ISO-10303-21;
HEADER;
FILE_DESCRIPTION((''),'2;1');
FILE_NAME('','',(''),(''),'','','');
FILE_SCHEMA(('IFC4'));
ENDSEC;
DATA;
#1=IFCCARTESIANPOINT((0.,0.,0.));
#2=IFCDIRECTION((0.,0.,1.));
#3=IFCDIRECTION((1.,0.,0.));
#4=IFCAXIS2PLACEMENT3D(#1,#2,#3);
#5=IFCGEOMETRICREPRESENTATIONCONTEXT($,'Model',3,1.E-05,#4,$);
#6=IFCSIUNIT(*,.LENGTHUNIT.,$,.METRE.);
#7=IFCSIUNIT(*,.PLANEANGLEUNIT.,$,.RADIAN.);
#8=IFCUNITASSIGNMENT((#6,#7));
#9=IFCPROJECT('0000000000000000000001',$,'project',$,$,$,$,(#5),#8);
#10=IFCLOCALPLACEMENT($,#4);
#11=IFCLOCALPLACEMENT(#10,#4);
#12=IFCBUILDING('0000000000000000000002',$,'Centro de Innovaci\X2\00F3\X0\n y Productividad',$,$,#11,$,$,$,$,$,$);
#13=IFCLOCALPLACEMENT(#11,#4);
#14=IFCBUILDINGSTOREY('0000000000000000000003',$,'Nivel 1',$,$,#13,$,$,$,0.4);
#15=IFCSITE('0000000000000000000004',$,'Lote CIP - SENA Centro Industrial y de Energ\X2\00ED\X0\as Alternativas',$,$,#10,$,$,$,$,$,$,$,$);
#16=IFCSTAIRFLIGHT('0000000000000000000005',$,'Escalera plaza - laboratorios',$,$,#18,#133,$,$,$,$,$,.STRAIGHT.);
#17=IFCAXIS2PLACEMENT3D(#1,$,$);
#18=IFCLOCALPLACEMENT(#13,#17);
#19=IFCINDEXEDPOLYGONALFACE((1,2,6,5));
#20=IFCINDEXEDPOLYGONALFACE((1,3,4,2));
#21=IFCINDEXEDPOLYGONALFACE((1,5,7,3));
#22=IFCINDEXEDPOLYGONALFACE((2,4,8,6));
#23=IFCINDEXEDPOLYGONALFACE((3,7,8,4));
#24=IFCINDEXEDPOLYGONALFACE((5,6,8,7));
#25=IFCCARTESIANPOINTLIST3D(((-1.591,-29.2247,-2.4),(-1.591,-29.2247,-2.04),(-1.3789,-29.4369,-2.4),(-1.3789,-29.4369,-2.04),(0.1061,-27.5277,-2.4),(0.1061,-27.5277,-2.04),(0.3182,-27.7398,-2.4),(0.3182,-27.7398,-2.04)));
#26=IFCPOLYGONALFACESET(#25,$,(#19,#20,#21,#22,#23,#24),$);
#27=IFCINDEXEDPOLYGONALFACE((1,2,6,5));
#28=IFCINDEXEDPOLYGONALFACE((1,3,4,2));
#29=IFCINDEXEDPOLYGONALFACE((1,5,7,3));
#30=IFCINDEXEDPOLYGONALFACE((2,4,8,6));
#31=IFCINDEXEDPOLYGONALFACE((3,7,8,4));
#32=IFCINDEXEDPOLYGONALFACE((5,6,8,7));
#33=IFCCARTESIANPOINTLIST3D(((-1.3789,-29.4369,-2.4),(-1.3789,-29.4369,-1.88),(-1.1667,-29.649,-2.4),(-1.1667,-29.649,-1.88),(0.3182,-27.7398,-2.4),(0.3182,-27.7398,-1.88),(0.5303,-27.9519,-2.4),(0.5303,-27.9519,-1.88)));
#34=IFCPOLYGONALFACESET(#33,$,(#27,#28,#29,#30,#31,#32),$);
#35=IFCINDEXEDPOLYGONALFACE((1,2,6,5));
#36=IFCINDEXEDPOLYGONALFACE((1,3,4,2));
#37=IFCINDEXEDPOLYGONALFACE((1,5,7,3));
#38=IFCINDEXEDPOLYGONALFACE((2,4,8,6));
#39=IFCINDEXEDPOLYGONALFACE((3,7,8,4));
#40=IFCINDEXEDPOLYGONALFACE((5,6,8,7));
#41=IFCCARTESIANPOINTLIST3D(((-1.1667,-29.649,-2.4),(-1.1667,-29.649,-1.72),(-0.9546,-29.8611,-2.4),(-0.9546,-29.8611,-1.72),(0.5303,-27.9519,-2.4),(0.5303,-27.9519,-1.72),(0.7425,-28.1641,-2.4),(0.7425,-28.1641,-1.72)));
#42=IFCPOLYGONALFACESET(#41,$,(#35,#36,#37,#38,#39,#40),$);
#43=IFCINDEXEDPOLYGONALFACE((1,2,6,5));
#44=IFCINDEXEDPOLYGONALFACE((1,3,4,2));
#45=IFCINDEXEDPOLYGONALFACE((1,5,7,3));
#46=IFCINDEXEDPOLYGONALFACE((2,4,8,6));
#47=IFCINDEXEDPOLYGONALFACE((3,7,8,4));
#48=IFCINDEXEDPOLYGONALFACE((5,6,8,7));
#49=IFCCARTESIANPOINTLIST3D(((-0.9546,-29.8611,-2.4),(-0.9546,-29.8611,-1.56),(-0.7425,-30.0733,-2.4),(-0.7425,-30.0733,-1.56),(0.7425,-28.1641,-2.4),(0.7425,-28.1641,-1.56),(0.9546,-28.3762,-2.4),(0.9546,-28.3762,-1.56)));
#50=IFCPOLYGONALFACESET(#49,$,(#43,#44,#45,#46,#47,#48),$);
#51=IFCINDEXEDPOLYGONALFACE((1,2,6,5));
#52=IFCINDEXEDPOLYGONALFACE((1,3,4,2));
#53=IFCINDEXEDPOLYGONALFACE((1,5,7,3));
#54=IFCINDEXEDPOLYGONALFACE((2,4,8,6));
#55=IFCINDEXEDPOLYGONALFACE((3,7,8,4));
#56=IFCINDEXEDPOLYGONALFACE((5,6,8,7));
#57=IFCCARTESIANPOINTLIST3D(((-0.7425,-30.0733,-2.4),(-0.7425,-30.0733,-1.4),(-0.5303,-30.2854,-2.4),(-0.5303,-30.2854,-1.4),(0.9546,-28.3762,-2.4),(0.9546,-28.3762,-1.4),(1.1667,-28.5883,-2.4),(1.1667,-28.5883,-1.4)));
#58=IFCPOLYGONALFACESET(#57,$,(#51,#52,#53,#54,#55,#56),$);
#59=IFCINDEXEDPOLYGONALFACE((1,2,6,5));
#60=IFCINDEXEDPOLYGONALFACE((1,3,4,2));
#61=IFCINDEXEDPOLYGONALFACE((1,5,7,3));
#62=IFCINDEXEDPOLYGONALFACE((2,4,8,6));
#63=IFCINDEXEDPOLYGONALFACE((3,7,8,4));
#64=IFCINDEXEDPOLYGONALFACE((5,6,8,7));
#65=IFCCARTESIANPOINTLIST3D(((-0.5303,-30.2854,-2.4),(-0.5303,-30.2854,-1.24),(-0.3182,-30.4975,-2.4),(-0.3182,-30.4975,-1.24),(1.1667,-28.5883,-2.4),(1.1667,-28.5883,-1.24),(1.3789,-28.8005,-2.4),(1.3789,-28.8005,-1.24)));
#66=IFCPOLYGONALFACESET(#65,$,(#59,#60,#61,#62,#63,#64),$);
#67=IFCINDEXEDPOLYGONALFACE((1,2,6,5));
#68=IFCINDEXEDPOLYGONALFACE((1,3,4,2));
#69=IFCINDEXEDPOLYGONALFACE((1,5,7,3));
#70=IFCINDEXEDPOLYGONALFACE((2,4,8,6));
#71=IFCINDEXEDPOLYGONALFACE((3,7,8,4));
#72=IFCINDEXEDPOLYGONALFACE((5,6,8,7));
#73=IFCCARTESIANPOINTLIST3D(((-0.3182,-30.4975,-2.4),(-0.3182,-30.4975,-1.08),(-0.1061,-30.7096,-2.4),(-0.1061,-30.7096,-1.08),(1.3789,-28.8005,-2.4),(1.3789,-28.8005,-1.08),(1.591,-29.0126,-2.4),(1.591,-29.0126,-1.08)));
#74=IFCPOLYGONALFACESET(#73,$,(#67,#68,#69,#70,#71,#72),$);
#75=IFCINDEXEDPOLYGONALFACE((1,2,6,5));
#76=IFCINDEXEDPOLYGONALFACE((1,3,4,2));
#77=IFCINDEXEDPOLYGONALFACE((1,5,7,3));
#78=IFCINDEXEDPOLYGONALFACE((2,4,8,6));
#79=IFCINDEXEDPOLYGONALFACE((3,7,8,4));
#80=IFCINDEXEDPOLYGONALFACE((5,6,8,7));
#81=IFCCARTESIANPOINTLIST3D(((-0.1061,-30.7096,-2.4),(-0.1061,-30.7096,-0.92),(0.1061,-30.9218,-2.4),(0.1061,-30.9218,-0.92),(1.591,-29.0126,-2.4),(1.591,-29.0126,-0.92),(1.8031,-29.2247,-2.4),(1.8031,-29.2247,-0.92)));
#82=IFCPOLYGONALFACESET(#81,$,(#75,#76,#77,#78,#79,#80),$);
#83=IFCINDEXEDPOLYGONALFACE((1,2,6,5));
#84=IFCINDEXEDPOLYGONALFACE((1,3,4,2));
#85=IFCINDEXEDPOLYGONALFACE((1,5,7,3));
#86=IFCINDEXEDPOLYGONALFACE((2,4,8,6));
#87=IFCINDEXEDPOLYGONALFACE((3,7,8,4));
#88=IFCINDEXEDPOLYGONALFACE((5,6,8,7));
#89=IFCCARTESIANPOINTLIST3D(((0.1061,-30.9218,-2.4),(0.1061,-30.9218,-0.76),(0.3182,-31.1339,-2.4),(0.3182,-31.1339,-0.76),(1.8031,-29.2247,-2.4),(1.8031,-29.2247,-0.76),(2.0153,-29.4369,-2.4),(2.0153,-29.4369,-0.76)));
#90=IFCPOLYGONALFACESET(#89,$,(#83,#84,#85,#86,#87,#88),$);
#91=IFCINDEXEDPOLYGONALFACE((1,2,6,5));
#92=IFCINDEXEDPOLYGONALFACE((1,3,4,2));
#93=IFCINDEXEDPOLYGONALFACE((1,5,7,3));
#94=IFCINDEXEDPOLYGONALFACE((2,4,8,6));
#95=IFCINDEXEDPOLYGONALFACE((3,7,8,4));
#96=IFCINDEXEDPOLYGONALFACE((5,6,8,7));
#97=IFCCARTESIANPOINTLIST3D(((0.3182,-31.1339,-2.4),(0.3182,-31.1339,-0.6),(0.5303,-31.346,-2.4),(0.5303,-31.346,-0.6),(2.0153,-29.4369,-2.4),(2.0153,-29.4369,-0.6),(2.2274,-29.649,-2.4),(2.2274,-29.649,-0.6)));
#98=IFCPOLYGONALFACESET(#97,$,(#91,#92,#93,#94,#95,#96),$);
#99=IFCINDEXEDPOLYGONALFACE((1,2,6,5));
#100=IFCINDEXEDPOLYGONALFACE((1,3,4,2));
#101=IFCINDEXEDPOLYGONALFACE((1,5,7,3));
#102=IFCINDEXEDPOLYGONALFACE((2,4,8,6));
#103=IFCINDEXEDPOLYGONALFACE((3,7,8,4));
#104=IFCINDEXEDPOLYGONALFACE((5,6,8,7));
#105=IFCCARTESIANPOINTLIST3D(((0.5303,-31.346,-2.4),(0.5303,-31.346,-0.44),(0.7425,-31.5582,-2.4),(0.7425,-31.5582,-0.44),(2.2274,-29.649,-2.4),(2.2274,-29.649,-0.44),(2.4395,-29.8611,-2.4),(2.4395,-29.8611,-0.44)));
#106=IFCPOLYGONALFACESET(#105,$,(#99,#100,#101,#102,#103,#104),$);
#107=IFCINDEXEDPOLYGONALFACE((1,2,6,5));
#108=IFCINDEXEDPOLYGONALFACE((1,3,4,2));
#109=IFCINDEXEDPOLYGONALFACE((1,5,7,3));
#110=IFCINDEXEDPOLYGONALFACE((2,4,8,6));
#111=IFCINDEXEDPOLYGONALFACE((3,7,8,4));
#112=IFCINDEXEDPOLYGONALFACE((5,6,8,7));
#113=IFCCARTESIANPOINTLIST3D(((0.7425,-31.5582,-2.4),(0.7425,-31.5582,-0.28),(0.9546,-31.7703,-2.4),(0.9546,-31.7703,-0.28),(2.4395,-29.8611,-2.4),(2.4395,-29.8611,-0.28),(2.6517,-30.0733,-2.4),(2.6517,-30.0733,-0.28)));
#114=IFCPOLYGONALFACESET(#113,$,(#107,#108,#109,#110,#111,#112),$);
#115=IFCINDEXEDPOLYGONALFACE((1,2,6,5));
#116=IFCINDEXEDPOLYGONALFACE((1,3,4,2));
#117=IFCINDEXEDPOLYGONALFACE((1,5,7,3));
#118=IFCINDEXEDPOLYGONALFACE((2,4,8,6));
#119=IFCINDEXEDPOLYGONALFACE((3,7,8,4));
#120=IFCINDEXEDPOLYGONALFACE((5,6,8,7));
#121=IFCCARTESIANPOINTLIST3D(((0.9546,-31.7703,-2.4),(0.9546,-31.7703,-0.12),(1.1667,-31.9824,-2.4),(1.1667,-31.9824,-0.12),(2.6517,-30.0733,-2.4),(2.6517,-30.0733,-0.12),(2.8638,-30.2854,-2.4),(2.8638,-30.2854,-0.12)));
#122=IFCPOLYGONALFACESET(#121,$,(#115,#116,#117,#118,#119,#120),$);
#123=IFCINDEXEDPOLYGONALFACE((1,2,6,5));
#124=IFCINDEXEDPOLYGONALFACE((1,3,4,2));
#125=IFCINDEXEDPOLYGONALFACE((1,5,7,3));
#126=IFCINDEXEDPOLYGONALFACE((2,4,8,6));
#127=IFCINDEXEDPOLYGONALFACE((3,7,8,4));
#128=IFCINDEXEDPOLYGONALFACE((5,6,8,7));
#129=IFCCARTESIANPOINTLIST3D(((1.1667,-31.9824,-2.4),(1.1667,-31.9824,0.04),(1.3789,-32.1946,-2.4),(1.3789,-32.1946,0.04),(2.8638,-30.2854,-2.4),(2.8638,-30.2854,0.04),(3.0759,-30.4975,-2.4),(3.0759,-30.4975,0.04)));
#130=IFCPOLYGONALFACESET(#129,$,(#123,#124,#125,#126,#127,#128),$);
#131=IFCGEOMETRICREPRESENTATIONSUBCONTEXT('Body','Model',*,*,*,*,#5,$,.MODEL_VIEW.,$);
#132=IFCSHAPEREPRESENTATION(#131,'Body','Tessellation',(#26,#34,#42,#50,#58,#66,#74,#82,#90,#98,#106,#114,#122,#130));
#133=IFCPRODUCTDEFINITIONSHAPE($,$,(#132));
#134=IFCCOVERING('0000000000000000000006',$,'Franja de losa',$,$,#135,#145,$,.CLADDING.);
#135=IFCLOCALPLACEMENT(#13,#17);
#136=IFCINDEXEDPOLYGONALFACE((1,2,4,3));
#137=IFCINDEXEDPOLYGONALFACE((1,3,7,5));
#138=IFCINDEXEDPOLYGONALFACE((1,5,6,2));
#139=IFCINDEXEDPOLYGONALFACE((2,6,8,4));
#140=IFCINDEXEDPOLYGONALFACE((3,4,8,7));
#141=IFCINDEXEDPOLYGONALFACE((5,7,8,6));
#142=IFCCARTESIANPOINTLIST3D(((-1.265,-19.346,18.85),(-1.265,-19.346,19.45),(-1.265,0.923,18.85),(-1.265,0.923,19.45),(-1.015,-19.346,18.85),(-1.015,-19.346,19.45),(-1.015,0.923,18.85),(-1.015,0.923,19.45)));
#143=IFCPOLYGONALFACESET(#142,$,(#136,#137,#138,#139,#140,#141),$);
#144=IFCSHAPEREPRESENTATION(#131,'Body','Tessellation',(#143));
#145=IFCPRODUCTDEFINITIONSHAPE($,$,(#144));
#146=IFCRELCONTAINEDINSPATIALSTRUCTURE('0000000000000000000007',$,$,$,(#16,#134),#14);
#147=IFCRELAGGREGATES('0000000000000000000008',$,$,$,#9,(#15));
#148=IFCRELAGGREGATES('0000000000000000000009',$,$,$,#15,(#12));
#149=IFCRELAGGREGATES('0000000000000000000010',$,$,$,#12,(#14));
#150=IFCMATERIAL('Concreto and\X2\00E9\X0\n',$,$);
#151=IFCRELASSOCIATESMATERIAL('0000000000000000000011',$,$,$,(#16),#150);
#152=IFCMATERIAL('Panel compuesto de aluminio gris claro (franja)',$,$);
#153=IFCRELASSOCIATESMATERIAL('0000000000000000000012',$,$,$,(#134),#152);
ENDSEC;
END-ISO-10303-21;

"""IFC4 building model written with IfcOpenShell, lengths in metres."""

from ifc_helpers import new_model, si_unit, frame, origin_with_axes, place, context, subcontext, project, spatial, polyline, outline, extrude, material, element, save


model = new_model("IFC4")

# Units and contexts
model_context = context("Model", 3, precision=1e-05, world=origin_with_axes())
body_context = subcontext(model_context, "Body", "Model", "MODEL_VIEW")
ifc_project = project(units=[si_unit("LENGTHUNIT", "METRE"), si_unit("PLANEANGLEUNIT", "RADIAN")], contexts=[model_context])

# Site, building, storey
site_placement = place(None, origin_with_axes())
site = spatial("IfcSite", under=ifc_project, at=site_placement, Name="Lote CIP - SENA Centro Industrial y de Energías Alternativas")
building_placement = place(site_placement, origin_with_axes())
building = spatial("IfcBuilding", under=site, at=building_placement, Name="Centro de Innovación y Productividad")
storey_placement = place(building_placement, origin_with_axes())
storey = spatial("IfcBuildingStorey", under=building, at=storey_placement, Name="Nivel 1", Elevation=0.4)

# Shared definitions
ifc_material_1 = material(Name="Concreto andén")

# Stair flight
stair_flight_1_placement = place(storey_placement, origin_with_axes())
element("IfcStairFlight", 1, at=stair_flight_1_placement, inside=storey, material=ifc_material_1, Name="Escalera plaza - laboratorios", PredefinedType="STRAIGHT", context=body_context, shape_type="SweptSolid", body=[
    extrude(outline(polyline([(-1.591, -29.2247), (0.1061, -27.5277), (0.3182, -27.7398), (-1.3789, -29.4369), (-1.591, -29.2247)])), frame((0.0, 0.0, -2.4)), (0.0, 0.0, 1.0), 0.36),
    extrude(outline(polyline([(-1.3789, -29.4369), (0.3182, -27.7398), (0.5303, -27.9519), (-1.1667, -29.649), (-1.3789, -29.4369)])), frame((0.0, 0.0, -2.4)), (0.0, 0.0, 1.0), 0.52),
    extrude(outline(polyline([(-1.1667, -29.649), (0.5303, -27.9519), (0.7425, -28.1641), (-0.9546, -29.8611), (-1.1667, -29.649)])), frame((0.0, 0.0, -2.4)), (0.0, 0.0, 1.0), 0.68),
    extrude(outline(polyline([(-0.9546, -29.8611), (0.7425, -28.1641), (0.9546, -28.3762), (-0.7425, -30.0733), (-0.9546, -29.8611)])), frame((0.0, 0.0, -2.4)), (0.0, 0.0, 1.0), 0.84),
    extrude(outline(polyline([(-0.7425, -30.0733), (0.9546, -28.3762), (1.1667, -28.5883), (-0.5303, -30.2854), (-0.7425, -30.0733)])), frame((0.0, 0.0, -2.4)), (0.0, 0.0, 1.0), 1.0),
    extrude(outline(polyline([(-0.5303, -30.2854), (1.1667, -28.5883), (1.3789, -28.8005), (-0.3182, -30.4975), (-0.5303, -30.2854)])), frame((0.0, 0.0, -2.4)), (0.0, 0.0, 1.0), 1.16),
    extrude(outline(polyline([(-0.3182, -30.4975), (1.3789, -28.8005), (1.591, -29.0126), (-0.1061, -30.7096), (-0.3182, -30.4975)])), frame((0.0, 0.0, -2.4)), (0.0, 0.0, 1.0), 1.32),
    extrude(outline(polyline([(-0.1061, -30.7096), (1.591, -29.0126), (1.8031, -29.2247), (0.1061, -30.9218), (-0.1061, -30.7096)])), frame((0.0, 0.0, -2.4)), (0.0, 0.0, 1.0), 1.48),
    extrude(outline(polyline([(0.1061, -30.9218), (1.8031, -29.2247), (2.0153, -29.4369), (0.3182, -31.1339), (0.1061, -30.9218)])), frame((0.0, 0.0, -2.4)), (0.0, 0.0, 1.0), 1.64),
    extrude(outline(polyline([(0.3182, -31.1339), (2.0153, -29.4369), (2.2274, -29.649), (0.5303, -31.346), (0.3182, -31.1339)])), frame((0.0, 0.0, -2.4)), (0.0, 0.0, 1.0), 1.8),
    extrude(outline(polyline([(0.5303, -31.346), (2.2274, -29.649), (2.4395, -29.8611), (0.7425, -31.5582), (0.5303, -31.346)])), frame((0.0, 0.0, -2.4)), (0.0, 0.0, 1.0), 1.96),
    extrude(outline(polyline([(0.7425, -31.5582), (2.4395, -29.8611), (2.6517, -30.0733), (0.9546, -31.7703), (0.7425, -31.5582)])), frame((0.0, 0.0, -2.4)), (0.0, 0.0, 1.0), 2.12),
    extrude(outline(polyline([(0.9546, -31.7703), (2.6517, -30.0733), (2.8638, -30.2854), (1.1667, -31.9824), (0.9546, -31.7703)])), frame((0.0, 0.0, -2.4)), (0.0, 0.0, 1.0), 2.28),
    extrude(outline(polyline([(1.1667, -31.9824), (2.8638, -30.2854), (3.0759, -30.4975), (1.3789, -32.1946), (1.1667, -31.9824)])), frame((0.0, 0.0, -2.4)), (0.0, 0.0, 1.0), 2.44),
])

# Covering
ifc_material_2 = material(Name="Panel compuesto de aluminio gris claro (franja)")
covering_placement = place(storey_placement, origin_with_axes())
element("IfcCovering", 2, at=covering_placement, inside=storey, material=ifc_material_2, Name="Franja de losa", PredefinedType="CLADDING", context=body_context, shape_type="SweptSolid", body=[
    extrude(outline(polyline([(-1.015, -19.346), (-1.265, -19.346), (-1.265, 0.923), (-1.015, 0.923), (-1.015, -19.346)])), frame((0.0, 0.0, 18.85)), (0.0, 0.0, 1.0), 0.6),
])

save(model, "model.ifc")
